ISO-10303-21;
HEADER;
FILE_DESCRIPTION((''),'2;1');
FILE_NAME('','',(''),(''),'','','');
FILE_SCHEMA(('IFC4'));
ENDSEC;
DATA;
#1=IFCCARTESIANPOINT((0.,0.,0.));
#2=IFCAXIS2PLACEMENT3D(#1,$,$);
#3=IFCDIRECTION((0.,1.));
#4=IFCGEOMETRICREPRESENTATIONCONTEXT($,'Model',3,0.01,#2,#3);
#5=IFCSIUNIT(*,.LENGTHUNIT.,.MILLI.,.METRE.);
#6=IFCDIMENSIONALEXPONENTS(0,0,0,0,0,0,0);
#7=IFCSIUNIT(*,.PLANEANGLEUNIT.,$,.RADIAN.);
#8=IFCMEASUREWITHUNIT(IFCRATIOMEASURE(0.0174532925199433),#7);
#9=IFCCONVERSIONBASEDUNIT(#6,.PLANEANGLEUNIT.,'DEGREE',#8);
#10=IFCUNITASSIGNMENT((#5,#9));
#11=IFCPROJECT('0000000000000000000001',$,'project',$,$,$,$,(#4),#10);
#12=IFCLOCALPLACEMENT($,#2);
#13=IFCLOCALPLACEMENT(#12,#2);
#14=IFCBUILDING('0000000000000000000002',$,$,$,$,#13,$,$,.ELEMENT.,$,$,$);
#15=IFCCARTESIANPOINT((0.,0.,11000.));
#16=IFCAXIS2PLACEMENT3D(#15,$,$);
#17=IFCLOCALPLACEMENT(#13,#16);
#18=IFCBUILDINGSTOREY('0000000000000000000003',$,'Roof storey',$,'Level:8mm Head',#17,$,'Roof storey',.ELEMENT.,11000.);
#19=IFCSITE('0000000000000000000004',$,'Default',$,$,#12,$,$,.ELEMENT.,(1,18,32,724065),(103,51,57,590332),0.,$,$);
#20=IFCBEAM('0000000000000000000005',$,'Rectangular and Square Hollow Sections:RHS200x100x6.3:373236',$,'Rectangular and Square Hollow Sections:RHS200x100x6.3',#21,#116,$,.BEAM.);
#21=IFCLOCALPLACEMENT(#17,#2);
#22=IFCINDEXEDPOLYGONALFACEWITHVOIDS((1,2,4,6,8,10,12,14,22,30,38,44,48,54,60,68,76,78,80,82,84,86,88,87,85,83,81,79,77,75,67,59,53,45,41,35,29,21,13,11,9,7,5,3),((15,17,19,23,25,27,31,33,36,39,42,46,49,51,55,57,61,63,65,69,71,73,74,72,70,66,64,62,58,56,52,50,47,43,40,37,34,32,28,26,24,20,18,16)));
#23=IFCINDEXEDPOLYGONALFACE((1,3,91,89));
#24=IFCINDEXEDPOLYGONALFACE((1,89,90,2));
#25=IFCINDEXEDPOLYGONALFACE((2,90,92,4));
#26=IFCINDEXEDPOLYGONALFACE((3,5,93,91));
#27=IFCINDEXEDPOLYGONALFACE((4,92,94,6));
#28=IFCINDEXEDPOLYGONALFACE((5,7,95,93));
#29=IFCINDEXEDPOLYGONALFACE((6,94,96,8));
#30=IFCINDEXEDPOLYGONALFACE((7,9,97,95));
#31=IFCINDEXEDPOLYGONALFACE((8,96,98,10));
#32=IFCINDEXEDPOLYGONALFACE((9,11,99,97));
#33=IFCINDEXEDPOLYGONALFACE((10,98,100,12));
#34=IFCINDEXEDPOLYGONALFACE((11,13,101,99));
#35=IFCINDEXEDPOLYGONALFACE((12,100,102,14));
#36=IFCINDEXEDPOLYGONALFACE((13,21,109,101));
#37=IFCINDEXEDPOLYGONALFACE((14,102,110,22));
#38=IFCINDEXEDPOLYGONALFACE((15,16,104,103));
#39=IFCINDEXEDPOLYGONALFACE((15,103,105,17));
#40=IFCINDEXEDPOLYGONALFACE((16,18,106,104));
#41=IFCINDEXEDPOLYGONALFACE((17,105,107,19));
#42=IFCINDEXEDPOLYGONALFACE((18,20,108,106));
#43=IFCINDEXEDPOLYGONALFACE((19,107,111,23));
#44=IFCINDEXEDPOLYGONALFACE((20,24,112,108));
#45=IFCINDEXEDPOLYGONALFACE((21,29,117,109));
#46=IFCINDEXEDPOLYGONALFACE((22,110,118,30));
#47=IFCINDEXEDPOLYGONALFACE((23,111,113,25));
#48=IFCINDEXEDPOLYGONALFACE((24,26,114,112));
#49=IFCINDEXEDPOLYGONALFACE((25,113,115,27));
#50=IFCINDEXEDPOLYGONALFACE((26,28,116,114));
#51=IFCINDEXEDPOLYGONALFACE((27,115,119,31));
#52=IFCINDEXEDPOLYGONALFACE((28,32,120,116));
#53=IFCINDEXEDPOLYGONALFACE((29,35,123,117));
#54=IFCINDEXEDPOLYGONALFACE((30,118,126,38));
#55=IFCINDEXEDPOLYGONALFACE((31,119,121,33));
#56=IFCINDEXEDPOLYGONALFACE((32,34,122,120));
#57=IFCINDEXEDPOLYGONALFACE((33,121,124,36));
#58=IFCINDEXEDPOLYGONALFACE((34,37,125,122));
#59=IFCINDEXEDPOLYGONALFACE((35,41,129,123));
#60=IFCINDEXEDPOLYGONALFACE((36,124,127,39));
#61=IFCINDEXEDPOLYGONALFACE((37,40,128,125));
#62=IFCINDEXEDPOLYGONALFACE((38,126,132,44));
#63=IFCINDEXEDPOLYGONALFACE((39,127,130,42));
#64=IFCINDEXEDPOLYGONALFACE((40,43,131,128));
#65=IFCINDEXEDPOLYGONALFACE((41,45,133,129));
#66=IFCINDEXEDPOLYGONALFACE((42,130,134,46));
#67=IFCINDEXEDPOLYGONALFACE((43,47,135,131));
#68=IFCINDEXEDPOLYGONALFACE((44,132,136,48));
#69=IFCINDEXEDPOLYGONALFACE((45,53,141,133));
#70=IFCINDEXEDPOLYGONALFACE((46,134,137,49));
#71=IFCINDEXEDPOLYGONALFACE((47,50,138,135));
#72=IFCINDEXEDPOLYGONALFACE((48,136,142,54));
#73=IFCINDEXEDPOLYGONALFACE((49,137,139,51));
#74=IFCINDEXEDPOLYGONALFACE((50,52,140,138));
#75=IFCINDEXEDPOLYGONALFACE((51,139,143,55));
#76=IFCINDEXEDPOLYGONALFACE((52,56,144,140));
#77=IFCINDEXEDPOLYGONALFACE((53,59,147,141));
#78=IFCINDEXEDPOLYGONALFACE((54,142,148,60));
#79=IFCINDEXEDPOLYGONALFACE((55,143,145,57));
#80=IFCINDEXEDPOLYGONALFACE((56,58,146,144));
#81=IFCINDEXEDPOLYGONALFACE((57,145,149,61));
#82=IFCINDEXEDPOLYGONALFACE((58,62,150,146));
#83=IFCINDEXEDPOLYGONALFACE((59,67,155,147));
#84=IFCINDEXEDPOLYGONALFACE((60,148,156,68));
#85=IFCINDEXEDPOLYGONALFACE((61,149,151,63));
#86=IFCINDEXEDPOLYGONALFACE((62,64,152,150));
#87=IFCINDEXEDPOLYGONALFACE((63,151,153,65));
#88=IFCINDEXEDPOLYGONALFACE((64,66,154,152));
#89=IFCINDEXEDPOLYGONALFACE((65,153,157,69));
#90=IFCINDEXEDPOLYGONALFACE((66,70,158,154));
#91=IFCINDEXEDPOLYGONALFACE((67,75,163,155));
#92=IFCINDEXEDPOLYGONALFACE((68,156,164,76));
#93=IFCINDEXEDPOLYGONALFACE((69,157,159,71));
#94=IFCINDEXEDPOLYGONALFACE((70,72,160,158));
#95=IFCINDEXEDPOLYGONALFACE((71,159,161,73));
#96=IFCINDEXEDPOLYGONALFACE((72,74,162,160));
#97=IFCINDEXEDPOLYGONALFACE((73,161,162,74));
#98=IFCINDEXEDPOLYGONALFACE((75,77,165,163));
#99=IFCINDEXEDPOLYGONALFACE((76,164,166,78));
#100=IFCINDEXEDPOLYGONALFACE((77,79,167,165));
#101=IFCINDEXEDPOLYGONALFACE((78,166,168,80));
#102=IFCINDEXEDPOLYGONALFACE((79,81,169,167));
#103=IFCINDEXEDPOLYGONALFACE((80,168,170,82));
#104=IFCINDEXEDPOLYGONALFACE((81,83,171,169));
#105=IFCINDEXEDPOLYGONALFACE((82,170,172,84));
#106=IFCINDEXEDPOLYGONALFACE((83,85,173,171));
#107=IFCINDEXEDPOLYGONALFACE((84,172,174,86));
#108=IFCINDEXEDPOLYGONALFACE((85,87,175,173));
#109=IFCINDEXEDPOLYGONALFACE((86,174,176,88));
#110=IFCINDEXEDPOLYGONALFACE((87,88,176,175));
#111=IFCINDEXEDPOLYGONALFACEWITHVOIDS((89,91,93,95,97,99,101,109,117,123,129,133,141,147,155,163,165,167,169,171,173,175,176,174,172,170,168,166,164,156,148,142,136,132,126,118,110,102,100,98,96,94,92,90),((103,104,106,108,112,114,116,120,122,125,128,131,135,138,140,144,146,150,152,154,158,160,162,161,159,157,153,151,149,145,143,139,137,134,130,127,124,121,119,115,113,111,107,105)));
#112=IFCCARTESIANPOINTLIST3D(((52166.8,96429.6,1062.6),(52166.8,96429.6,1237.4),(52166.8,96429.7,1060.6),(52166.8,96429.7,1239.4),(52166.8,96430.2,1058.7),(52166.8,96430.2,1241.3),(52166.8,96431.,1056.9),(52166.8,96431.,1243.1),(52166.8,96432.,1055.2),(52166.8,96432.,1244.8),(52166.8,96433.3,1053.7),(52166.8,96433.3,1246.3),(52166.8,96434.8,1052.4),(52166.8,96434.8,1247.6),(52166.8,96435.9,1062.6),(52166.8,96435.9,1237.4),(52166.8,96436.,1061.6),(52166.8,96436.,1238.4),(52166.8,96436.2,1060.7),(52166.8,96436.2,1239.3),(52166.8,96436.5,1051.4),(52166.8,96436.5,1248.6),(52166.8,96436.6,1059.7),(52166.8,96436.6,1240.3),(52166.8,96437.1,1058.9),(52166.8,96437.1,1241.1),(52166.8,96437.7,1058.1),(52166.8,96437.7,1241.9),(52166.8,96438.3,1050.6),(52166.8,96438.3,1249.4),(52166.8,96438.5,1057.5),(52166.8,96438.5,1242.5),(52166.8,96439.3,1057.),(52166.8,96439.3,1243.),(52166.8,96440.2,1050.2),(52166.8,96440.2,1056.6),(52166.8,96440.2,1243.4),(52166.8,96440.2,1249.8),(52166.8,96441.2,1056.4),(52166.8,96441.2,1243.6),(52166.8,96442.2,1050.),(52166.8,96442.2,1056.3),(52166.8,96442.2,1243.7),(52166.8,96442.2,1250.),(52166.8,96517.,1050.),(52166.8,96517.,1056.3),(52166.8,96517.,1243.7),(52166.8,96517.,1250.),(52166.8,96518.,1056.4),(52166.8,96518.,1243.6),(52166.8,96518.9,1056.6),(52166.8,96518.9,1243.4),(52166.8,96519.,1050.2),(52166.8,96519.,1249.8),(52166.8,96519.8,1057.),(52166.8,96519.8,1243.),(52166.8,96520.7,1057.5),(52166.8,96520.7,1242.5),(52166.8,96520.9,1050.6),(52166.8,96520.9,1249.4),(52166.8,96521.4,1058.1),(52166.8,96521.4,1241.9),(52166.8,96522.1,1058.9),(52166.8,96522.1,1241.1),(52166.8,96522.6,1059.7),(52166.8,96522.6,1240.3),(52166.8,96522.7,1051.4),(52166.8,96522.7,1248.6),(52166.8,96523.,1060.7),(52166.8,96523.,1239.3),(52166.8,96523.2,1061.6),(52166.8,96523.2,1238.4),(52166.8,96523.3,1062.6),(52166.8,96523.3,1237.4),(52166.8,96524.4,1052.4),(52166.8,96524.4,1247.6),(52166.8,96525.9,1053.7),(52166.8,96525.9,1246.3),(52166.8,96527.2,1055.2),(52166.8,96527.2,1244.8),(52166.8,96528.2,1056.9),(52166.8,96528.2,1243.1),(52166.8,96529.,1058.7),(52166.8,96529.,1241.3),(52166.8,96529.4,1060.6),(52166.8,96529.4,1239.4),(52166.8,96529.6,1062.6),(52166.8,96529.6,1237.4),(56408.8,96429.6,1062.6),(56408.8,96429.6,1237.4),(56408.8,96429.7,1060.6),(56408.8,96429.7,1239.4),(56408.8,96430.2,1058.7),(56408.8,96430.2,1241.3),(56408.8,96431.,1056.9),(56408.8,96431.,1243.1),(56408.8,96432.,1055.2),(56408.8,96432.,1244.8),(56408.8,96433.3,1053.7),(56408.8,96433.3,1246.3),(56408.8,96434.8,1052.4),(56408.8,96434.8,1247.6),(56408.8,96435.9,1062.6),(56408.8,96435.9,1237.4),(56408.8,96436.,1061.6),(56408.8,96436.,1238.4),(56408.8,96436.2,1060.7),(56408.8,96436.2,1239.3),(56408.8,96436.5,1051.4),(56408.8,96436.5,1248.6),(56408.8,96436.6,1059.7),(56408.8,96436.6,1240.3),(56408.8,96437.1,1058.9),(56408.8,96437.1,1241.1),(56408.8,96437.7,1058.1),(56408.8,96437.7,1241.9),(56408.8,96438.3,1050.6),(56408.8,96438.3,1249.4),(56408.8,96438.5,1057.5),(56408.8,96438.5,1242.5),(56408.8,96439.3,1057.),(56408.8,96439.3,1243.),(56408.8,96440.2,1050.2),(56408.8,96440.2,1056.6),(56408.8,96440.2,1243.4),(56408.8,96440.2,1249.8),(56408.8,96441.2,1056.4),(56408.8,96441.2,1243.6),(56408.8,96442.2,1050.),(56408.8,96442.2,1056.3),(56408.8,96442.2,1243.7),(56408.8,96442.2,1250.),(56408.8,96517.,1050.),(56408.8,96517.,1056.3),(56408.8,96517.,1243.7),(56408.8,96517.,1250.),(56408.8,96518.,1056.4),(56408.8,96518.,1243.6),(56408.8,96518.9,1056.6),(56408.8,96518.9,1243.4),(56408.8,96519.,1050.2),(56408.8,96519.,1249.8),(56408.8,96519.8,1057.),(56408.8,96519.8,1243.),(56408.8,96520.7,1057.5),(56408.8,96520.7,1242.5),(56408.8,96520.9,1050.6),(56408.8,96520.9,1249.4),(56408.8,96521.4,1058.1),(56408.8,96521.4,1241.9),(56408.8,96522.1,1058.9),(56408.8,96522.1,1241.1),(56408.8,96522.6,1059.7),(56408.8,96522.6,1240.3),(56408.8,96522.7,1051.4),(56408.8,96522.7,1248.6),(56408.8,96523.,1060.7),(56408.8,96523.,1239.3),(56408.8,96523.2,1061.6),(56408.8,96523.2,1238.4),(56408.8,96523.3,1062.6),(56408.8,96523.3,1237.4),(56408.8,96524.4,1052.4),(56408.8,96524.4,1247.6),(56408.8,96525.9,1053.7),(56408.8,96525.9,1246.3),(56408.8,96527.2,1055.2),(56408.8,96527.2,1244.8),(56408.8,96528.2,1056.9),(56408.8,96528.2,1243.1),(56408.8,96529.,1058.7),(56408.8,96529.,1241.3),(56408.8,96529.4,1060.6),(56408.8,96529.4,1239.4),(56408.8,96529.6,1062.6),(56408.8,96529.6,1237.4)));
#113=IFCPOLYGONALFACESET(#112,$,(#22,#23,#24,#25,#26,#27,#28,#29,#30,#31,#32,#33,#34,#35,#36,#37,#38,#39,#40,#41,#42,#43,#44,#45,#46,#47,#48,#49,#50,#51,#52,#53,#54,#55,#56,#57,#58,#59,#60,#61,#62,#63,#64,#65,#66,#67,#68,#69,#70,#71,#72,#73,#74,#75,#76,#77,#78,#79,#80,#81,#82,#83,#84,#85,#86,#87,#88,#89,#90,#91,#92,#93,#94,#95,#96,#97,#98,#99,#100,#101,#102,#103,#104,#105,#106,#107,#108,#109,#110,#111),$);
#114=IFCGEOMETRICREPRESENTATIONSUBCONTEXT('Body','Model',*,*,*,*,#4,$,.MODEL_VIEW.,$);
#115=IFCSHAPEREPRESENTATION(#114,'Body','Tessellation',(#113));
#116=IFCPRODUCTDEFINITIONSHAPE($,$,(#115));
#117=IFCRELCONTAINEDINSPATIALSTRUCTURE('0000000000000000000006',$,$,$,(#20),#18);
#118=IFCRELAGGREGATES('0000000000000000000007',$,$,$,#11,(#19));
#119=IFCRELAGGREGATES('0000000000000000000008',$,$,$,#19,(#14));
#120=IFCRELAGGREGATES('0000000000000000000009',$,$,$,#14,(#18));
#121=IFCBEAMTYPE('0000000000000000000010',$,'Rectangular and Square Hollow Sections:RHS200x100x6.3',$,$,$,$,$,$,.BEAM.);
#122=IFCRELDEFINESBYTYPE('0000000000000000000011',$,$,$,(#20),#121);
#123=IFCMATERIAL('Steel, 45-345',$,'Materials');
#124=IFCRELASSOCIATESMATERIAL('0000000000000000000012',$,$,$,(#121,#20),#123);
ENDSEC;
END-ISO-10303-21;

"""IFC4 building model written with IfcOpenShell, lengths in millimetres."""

from ifc_helpers import new_model, entity, si_unit, converted_unit, direction, frame, origin, place, context, subcontext, project, spatial, indexed_curve, outline, extrude, source, transform, mapped, material, type_object, type_shapes, element, save


model = new_model("IFC4")

# Units and contexts
model_context = context("Model", 3, precision=0.01, world=origin(), true_north=direction((0.0, 1.0)))
body_context = subcontext(model_context, "Body", "Model", "MODEL_VIEW")
ifc_project = project(units=[si_unit("LENGTHUNIT", "METRE", prefix="MILLI"), converted_unit("PLANEANGLEUNIT", "DEGREE", entity("IfcRatioMeasure", 0.0174532925199433), si_unit("PLANEANGLEUNIT", "RADIAN"), dimensions=[0, 0, 0, 0, 0, 0, 0])], contexts=[model_context])

# Site, building, storey
site_placement = place(None, origin())
site = spatial("IfcSite", under=ifc_project, at=site_placement, Name="Default", CompositionType="ELEMENT", RefLatitude=(1, 18, 32, 724065), RefLongitude=(103, 51, 57, 590332), RefElevation=0.0)
building_placement = place(site_placement, origin())
building = spatial("IfcBuilding", under=site, at=building_placement, CompositionType="ELEMENT")
storey_placement = place(building_placement, frame((0.0, 0.0, 11000.0)))
storey = spatial("IfcBuildingStorey", under=building, at=storey_placement, Name="Roof storey", ObjectType="Level:8mm Head", LongName="Roof storey", CompositionType="ELEMENT", Elevation=11000.0)

# Shared definitions
ifc_material = material(Name="Steel, 45-345", Category="Materials")

# Beam
beam_type_1 = type_object("IfcBeamType", Name="Rectangular and Square Hollow Sections:RHS200x100x6.3", PredefinedType="BEAM", material=ifc_material)
shared_shape_1 = source(origin(), body_context, "Body", "SweptSolid", [
    extrude(outline(indexed_curve([(-50.0, -87.4), (-49.8, -89.4), (-49.4, -91.3), (-48.6, -93.1), (-47.6, -94.8), (-46.3, -96.3), (-44.8, -97.6), (-43.1, -98.6), (-41.3, -99.4), (-39.4, -99.8), (-37.4, -100.0), (37.4, -100.0), (39.4, -99.8), (41.3, -99.4), (43.1, -98.6), (44.8, -97.6), (46.3, -96.3), (47.6, -94.8), (48.6, -93.1), (49.4, -91.3), (49.8, -89.4), (50.0, -87.4), (50.0, 87.4), (49.8, 89.4), (49.4, 91.3), (48.6, 93.1), (47.6, 94.8), (46.3, 96.3), (44.8, 97.6), (43.1, 98.6), (41.3, 99.4), (39.4, 99.8), (37.4, 100.0), (-37.4, 100.0), (-39.4, 99.8), (-41.3, 99.4), (-43.1, 98.6), (-44.8, 97.6), (-46.3, 96.3), (-47.6, 94.8), (-48.6, 93.1), (-49.4, 91.3), (-49.8, 89.4), (-50.0, 87.4), (-50.0, -87.4)], self_intersect=False), holes=[indexed_curve([(37.4, -93.7), (-37.4, -93.7), (-38.4, -93.6), (-39.3, -93.4), (-40.3, -93.0), (-41.1, -92.5), (-41.9, -91.9), (-42.5, -91.1), (-43.0, -90.3), (-43.4, -89.3), (-43.6, -88.4), (-43.7, -87.4), (-43.7, 87.4), (-43.6, 88.4), (-43.4, 89.3), (-43.0, 90.3), (-42.5, 91.1), (-41.9, 91.9), (-41.1, 92.5), (-40.3, 93.0), (-39.3, 93.4), (-38.4, 93.6), (-37.4, 93.7), (37.4, 93.7), (38.4, 93.6), (39.3, 93.4), (40.3, 93.0), (41.1, 92.5), (41.9, 91.9), (42.5, 91.1), (43.0, 90.3), (43.4, 89.3), (43.6, 88.4), (43.7, 87.4), (43.7, -87.4), (43.6, -88.4), (43.4, -89.3), (43.0, -90.3), (42.5, -91.1), (41.9, -91.9), (41.1, -92.5), (40.3, -93.0), (39.3, -93.4), (38.4, -93.6), (37.4, -93.7)], self_intersect=False)]), frame((-2090.0, 0.0, 0.0), z_axis=(1.0, 0.0, 0.0), x_axis=(0.0, -1.0, 0.0)), (0.0, 0.0, 1.0), 4242.0),
])
type_shapes(beam_type_1, [shared_shape_1])
beam_1_placement = place(storey_placement, frame((54256.8, 96479.6, 1150.0)))
element("IfcBeam", 1, at=beam_1_placement, inside=storey, type_object=beam_type_1, material=ifc_material, Name="Rectangular and Square Hollow Sections:RHS200x100x6.3:373236", ObjectType="Rectangular and Square Hollow Sections:RHS200x100x6.3", PredefinedType="BEAM", context=body_context, shape_type="MappedRepresentation", body=[
    mapped(shared_shape_1, transform((0.0, 0.0, 0.0), scale=1.0)),
])

save(model, "model.ifc")
